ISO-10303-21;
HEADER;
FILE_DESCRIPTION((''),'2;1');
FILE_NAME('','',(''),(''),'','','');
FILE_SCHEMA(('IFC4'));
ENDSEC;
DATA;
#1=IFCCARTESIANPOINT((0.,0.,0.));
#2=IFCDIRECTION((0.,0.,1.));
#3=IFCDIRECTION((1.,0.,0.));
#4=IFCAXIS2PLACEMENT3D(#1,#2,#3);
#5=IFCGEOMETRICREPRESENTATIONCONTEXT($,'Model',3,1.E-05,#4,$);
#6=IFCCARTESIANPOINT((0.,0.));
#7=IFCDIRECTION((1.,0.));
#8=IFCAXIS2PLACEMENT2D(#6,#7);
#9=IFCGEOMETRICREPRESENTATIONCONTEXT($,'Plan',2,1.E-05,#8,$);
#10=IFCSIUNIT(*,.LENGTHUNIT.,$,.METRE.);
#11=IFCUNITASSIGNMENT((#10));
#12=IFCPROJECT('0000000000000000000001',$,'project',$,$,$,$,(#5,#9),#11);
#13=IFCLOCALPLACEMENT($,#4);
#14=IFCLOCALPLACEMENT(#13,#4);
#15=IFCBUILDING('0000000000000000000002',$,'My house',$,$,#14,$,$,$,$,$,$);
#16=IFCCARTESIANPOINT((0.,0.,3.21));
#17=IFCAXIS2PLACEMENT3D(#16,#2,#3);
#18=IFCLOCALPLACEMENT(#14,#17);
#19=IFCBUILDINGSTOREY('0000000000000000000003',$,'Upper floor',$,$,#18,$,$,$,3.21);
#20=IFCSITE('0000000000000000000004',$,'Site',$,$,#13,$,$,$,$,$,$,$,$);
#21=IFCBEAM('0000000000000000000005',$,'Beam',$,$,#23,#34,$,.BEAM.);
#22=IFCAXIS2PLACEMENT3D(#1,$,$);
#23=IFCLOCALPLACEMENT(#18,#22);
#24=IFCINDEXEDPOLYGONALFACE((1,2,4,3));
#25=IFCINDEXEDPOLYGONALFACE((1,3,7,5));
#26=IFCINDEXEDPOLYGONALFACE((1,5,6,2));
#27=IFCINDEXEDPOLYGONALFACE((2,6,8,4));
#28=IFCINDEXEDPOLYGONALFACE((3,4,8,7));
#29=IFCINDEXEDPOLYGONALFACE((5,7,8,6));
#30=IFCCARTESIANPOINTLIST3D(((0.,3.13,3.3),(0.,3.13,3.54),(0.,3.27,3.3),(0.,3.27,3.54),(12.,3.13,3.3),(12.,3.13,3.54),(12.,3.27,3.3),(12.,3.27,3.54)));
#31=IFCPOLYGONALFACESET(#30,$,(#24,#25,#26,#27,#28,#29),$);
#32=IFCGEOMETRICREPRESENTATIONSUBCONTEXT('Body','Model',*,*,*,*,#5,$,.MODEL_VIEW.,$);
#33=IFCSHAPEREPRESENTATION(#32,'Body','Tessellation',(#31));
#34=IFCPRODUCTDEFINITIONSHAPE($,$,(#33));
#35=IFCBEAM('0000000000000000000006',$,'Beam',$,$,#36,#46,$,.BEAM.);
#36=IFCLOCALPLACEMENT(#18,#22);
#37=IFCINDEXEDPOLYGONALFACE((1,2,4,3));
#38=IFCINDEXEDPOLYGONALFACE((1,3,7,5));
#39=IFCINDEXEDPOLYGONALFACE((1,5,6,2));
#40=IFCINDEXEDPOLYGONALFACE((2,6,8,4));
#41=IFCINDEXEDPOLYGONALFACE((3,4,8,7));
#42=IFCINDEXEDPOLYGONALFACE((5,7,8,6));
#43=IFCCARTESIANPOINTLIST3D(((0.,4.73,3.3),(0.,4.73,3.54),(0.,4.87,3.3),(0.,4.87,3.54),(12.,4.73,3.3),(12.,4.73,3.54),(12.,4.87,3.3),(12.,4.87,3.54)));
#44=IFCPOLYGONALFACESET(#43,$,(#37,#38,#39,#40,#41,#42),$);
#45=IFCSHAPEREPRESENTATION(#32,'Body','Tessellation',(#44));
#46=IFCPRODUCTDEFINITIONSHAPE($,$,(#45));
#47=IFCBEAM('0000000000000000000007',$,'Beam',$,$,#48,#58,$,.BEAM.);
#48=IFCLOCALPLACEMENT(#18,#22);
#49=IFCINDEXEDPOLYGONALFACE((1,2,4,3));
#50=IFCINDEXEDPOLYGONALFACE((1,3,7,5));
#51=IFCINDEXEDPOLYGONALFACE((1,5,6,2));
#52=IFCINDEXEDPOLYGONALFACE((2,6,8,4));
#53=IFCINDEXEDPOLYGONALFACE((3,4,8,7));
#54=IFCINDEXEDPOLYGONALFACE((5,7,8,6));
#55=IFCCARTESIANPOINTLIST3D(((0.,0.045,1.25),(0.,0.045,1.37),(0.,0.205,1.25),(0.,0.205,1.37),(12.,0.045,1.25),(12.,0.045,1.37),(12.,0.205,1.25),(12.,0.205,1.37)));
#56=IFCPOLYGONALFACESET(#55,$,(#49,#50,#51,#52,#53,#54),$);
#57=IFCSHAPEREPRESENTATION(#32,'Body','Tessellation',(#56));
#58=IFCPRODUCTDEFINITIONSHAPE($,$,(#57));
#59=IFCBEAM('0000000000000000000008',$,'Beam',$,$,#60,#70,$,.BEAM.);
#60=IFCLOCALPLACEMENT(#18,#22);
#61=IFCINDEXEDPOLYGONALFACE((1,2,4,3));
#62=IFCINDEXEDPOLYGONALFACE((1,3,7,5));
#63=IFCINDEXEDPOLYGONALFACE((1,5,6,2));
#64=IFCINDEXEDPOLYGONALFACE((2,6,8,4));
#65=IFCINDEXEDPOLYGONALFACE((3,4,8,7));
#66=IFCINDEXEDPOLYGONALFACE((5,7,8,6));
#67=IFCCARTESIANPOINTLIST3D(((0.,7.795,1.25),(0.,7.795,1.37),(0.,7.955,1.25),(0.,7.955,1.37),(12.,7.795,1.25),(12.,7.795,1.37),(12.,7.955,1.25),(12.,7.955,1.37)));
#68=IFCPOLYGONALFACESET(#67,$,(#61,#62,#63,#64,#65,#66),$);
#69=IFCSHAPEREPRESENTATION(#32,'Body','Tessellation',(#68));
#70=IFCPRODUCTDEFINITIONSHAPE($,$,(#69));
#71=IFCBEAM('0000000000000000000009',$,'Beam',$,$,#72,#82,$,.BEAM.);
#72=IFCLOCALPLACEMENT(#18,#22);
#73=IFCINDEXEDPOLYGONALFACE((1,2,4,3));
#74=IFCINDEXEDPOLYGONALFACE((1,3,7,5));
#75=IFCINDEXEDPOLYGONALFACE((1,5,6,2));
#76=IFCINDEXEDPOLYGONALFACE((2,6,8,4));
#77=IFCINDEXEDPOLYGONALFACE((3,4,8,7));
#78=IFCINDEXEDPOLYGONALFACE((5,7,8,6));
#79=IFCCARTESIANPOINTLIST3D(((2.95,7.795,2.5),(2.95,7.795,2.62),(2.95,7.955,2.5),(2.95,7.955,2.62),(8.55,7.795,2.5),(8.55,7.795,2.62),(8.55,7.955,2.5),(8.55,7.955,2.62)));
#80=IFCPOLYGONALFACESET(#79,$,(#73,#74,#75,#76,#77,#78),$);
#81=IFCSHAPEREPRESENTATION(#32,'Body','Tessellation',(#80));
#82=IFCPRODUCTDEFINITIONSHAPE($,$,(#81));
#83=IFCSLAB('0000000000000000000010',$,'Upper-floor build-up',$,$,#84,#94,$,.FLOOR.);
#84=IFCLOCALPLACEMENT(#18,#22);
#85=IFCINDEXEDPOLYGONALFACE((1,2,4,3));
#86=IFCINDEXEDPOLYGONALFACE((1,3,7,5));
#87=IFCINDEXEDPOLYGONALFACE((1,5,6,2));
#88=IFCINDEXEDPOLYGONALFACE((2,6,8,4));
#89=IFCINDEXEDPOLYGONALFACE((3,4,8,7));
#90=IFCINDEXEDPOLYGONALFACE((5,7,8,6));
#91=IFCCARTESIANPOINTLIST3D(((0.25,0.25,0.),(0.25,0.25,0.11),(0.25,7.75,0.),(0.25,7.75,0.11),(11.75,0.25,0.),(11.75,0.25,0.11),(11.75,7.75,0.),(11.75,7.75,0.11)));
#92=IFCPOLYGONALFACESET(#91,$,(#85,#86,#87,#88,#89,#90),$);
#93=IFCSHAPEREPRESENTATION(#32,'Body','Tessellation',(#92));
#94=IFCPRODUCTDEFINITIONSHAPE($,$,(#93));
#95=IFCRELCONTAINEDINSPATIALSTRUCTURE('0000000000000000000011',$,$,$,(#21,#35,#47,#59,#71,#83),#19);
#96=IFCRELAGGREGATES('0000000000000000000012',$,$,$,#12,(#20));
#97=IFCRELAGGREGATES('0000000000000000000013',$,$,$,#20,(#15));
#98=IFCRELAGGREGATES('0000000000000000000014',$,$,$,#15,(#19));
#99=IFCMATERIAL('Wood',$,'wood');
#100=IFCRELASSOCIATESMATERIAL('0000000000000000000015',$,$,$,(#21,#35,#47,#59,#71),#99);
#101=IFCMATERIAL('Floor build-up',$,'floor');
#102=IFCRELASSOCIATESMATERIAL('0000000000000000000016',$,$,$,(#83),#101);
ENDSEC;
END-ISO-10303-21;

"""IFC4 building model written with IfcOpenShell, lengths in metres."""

from ifc_helpers import new_model, si_unit, frame, origin_with_axes, origin_2d_with_axis, place, context, subcontext, project, spatial, indexed_curve, rectangle, outline, extrude, material, element, save


model = new_model("IFC4")

# Units and contexts
model_context = context("Model", 3, precision=1e-05, world=origin_with_axes())
plan_context = context("Plan", 2, precision=1e-05, world=origin_2d_with_axis())
body_context_1 = subcontext(model_context, "Body", "Model", "MODEL_VIEW")
ifc_project = project(units=[si_unit("LENGTHUNIT", "METRE")], contexts=[model_context, plan_context])

# Site, building, storey
site_placement = place(None, origin_with_axes())
site = spatial("IfcSite", under=ifc_project, at=site_placement, Name="Site")
building_placement = place(site_placement, origin_with_axes())
building = spatial("IfcBuilding", under=site, at=building_placement, Name="My house")
storey_placement = place(building_placement, frame((0.0, 0.0, 3.21), z_axis=(0.0, 0.0, 1.0), x_axis=(1.0, 0.0, 0.0)))
storey = spatial("IfcBuildingStorey", under=building, at=storey_placement, Name="Upper floor", Elevation=3.21)

# Beams
ifc_material_1 = material(Name="Wood", Category="wood")
for number, where, z_axis, x_axis, name in (
    (1, (0.0, 3.2, 3.42), (0.0, 0.0, 1.0), (1.0, 0.0, 0.0), "Beam"),
    (2, (0.0, 4.8, 3.42), (0.0, 0.0, 1.0), (1.0, 0.0, 0.0), "Beam"),
):
    element("IfcBeam", number, at=place(storey_placement, frame(where, z_axis=z_axis, x_axis=x_axis)), inside=storey, material=ifc_material_1, Name=name, PredefinedType="BEAM", context=body_context_1, shape_type="SweptSolid", body=[
        extrude(rectangle(XDim=0.14, YDim=0.24), frame((0.0, 0.0, 0.0), z_axis=(1.0, 0.0, 0.0), x_axis=(0.0, 1.0, 0.0)), (0.0, 0.0, 1.0), 12.0),
    ])
for number, where, z_axis, x_axis, name in (
    (3, (0.0, 0.125, 1.31), (0.0, 0.0, 1.0), (1.0, 0.0, 0.0), "Beam"),
    (4, (0.0, 7.875, 1.31), (0.0, 0.0, 1.0), (1.0, 0.0, 0.0), "Beam"),
):
    element("IfcBeam", number, at=place(storey_placement, frame(where, z_axis=z_axis, x_axis=x_axis)), inside=storey, material=ifc_material_1, Name=name, PredefinedType="BEAM", context=body_context_1, shape_type="SweptSolid", body=[
        extrude(rectangle(XDim=0.16, YDim=0.12), frame((0.0, 0.0, 0.0), z_axis=(1.0, 0.0, 0.0), x_axis=(0.0, 1.0, 0.0)), (0.0, 0.0, 1.0), 12.0),
    ])
beam_placement = place(storey_placement, frame((8.55, 7.875, 2.56), z_axis=(0.0, 0.0, 1.0), x_axis=(-1.0, 0.0, 0.0)))
element("IfcBeam", 5, at=beam_placement, inside=storey, material=ifc_material_1, Name="Beam", PredefinedType="BEAM", context=body_context_1, shape_type="SweptSolid", body=[
    extrude(rectangle(XDim=0.16, YDim=0.12), frame((0.0, 0.0, 0.0), z_axis=(1.0, 0.0, 0.0), x_axis=(0.0, 1.0, 0.0)), (0.0, 0.0, 1.0), 5.6),
])

# Slab
ifc_material_2 = material(Name="Floor build-up", Category="floor")
slab_placement = place(storey_placement, origin_with_axes())
element("IfcSlab", 6, at=slab_placement, inside=storey, material=ifc_material_2, Name="Upper-floor build-up", PredefinedType="FLOOR", context=body_context_1, shape_type="SweptSolid", body=[
    extrude(outline(indexed_curve([(0.25, 0.25), (11.75, 0.25), (11.75, 7.75), (0.25, 7.75)])), None, (0.0, 0.0, 1.0), 0.11),
])

save(model, "model.ifc")
